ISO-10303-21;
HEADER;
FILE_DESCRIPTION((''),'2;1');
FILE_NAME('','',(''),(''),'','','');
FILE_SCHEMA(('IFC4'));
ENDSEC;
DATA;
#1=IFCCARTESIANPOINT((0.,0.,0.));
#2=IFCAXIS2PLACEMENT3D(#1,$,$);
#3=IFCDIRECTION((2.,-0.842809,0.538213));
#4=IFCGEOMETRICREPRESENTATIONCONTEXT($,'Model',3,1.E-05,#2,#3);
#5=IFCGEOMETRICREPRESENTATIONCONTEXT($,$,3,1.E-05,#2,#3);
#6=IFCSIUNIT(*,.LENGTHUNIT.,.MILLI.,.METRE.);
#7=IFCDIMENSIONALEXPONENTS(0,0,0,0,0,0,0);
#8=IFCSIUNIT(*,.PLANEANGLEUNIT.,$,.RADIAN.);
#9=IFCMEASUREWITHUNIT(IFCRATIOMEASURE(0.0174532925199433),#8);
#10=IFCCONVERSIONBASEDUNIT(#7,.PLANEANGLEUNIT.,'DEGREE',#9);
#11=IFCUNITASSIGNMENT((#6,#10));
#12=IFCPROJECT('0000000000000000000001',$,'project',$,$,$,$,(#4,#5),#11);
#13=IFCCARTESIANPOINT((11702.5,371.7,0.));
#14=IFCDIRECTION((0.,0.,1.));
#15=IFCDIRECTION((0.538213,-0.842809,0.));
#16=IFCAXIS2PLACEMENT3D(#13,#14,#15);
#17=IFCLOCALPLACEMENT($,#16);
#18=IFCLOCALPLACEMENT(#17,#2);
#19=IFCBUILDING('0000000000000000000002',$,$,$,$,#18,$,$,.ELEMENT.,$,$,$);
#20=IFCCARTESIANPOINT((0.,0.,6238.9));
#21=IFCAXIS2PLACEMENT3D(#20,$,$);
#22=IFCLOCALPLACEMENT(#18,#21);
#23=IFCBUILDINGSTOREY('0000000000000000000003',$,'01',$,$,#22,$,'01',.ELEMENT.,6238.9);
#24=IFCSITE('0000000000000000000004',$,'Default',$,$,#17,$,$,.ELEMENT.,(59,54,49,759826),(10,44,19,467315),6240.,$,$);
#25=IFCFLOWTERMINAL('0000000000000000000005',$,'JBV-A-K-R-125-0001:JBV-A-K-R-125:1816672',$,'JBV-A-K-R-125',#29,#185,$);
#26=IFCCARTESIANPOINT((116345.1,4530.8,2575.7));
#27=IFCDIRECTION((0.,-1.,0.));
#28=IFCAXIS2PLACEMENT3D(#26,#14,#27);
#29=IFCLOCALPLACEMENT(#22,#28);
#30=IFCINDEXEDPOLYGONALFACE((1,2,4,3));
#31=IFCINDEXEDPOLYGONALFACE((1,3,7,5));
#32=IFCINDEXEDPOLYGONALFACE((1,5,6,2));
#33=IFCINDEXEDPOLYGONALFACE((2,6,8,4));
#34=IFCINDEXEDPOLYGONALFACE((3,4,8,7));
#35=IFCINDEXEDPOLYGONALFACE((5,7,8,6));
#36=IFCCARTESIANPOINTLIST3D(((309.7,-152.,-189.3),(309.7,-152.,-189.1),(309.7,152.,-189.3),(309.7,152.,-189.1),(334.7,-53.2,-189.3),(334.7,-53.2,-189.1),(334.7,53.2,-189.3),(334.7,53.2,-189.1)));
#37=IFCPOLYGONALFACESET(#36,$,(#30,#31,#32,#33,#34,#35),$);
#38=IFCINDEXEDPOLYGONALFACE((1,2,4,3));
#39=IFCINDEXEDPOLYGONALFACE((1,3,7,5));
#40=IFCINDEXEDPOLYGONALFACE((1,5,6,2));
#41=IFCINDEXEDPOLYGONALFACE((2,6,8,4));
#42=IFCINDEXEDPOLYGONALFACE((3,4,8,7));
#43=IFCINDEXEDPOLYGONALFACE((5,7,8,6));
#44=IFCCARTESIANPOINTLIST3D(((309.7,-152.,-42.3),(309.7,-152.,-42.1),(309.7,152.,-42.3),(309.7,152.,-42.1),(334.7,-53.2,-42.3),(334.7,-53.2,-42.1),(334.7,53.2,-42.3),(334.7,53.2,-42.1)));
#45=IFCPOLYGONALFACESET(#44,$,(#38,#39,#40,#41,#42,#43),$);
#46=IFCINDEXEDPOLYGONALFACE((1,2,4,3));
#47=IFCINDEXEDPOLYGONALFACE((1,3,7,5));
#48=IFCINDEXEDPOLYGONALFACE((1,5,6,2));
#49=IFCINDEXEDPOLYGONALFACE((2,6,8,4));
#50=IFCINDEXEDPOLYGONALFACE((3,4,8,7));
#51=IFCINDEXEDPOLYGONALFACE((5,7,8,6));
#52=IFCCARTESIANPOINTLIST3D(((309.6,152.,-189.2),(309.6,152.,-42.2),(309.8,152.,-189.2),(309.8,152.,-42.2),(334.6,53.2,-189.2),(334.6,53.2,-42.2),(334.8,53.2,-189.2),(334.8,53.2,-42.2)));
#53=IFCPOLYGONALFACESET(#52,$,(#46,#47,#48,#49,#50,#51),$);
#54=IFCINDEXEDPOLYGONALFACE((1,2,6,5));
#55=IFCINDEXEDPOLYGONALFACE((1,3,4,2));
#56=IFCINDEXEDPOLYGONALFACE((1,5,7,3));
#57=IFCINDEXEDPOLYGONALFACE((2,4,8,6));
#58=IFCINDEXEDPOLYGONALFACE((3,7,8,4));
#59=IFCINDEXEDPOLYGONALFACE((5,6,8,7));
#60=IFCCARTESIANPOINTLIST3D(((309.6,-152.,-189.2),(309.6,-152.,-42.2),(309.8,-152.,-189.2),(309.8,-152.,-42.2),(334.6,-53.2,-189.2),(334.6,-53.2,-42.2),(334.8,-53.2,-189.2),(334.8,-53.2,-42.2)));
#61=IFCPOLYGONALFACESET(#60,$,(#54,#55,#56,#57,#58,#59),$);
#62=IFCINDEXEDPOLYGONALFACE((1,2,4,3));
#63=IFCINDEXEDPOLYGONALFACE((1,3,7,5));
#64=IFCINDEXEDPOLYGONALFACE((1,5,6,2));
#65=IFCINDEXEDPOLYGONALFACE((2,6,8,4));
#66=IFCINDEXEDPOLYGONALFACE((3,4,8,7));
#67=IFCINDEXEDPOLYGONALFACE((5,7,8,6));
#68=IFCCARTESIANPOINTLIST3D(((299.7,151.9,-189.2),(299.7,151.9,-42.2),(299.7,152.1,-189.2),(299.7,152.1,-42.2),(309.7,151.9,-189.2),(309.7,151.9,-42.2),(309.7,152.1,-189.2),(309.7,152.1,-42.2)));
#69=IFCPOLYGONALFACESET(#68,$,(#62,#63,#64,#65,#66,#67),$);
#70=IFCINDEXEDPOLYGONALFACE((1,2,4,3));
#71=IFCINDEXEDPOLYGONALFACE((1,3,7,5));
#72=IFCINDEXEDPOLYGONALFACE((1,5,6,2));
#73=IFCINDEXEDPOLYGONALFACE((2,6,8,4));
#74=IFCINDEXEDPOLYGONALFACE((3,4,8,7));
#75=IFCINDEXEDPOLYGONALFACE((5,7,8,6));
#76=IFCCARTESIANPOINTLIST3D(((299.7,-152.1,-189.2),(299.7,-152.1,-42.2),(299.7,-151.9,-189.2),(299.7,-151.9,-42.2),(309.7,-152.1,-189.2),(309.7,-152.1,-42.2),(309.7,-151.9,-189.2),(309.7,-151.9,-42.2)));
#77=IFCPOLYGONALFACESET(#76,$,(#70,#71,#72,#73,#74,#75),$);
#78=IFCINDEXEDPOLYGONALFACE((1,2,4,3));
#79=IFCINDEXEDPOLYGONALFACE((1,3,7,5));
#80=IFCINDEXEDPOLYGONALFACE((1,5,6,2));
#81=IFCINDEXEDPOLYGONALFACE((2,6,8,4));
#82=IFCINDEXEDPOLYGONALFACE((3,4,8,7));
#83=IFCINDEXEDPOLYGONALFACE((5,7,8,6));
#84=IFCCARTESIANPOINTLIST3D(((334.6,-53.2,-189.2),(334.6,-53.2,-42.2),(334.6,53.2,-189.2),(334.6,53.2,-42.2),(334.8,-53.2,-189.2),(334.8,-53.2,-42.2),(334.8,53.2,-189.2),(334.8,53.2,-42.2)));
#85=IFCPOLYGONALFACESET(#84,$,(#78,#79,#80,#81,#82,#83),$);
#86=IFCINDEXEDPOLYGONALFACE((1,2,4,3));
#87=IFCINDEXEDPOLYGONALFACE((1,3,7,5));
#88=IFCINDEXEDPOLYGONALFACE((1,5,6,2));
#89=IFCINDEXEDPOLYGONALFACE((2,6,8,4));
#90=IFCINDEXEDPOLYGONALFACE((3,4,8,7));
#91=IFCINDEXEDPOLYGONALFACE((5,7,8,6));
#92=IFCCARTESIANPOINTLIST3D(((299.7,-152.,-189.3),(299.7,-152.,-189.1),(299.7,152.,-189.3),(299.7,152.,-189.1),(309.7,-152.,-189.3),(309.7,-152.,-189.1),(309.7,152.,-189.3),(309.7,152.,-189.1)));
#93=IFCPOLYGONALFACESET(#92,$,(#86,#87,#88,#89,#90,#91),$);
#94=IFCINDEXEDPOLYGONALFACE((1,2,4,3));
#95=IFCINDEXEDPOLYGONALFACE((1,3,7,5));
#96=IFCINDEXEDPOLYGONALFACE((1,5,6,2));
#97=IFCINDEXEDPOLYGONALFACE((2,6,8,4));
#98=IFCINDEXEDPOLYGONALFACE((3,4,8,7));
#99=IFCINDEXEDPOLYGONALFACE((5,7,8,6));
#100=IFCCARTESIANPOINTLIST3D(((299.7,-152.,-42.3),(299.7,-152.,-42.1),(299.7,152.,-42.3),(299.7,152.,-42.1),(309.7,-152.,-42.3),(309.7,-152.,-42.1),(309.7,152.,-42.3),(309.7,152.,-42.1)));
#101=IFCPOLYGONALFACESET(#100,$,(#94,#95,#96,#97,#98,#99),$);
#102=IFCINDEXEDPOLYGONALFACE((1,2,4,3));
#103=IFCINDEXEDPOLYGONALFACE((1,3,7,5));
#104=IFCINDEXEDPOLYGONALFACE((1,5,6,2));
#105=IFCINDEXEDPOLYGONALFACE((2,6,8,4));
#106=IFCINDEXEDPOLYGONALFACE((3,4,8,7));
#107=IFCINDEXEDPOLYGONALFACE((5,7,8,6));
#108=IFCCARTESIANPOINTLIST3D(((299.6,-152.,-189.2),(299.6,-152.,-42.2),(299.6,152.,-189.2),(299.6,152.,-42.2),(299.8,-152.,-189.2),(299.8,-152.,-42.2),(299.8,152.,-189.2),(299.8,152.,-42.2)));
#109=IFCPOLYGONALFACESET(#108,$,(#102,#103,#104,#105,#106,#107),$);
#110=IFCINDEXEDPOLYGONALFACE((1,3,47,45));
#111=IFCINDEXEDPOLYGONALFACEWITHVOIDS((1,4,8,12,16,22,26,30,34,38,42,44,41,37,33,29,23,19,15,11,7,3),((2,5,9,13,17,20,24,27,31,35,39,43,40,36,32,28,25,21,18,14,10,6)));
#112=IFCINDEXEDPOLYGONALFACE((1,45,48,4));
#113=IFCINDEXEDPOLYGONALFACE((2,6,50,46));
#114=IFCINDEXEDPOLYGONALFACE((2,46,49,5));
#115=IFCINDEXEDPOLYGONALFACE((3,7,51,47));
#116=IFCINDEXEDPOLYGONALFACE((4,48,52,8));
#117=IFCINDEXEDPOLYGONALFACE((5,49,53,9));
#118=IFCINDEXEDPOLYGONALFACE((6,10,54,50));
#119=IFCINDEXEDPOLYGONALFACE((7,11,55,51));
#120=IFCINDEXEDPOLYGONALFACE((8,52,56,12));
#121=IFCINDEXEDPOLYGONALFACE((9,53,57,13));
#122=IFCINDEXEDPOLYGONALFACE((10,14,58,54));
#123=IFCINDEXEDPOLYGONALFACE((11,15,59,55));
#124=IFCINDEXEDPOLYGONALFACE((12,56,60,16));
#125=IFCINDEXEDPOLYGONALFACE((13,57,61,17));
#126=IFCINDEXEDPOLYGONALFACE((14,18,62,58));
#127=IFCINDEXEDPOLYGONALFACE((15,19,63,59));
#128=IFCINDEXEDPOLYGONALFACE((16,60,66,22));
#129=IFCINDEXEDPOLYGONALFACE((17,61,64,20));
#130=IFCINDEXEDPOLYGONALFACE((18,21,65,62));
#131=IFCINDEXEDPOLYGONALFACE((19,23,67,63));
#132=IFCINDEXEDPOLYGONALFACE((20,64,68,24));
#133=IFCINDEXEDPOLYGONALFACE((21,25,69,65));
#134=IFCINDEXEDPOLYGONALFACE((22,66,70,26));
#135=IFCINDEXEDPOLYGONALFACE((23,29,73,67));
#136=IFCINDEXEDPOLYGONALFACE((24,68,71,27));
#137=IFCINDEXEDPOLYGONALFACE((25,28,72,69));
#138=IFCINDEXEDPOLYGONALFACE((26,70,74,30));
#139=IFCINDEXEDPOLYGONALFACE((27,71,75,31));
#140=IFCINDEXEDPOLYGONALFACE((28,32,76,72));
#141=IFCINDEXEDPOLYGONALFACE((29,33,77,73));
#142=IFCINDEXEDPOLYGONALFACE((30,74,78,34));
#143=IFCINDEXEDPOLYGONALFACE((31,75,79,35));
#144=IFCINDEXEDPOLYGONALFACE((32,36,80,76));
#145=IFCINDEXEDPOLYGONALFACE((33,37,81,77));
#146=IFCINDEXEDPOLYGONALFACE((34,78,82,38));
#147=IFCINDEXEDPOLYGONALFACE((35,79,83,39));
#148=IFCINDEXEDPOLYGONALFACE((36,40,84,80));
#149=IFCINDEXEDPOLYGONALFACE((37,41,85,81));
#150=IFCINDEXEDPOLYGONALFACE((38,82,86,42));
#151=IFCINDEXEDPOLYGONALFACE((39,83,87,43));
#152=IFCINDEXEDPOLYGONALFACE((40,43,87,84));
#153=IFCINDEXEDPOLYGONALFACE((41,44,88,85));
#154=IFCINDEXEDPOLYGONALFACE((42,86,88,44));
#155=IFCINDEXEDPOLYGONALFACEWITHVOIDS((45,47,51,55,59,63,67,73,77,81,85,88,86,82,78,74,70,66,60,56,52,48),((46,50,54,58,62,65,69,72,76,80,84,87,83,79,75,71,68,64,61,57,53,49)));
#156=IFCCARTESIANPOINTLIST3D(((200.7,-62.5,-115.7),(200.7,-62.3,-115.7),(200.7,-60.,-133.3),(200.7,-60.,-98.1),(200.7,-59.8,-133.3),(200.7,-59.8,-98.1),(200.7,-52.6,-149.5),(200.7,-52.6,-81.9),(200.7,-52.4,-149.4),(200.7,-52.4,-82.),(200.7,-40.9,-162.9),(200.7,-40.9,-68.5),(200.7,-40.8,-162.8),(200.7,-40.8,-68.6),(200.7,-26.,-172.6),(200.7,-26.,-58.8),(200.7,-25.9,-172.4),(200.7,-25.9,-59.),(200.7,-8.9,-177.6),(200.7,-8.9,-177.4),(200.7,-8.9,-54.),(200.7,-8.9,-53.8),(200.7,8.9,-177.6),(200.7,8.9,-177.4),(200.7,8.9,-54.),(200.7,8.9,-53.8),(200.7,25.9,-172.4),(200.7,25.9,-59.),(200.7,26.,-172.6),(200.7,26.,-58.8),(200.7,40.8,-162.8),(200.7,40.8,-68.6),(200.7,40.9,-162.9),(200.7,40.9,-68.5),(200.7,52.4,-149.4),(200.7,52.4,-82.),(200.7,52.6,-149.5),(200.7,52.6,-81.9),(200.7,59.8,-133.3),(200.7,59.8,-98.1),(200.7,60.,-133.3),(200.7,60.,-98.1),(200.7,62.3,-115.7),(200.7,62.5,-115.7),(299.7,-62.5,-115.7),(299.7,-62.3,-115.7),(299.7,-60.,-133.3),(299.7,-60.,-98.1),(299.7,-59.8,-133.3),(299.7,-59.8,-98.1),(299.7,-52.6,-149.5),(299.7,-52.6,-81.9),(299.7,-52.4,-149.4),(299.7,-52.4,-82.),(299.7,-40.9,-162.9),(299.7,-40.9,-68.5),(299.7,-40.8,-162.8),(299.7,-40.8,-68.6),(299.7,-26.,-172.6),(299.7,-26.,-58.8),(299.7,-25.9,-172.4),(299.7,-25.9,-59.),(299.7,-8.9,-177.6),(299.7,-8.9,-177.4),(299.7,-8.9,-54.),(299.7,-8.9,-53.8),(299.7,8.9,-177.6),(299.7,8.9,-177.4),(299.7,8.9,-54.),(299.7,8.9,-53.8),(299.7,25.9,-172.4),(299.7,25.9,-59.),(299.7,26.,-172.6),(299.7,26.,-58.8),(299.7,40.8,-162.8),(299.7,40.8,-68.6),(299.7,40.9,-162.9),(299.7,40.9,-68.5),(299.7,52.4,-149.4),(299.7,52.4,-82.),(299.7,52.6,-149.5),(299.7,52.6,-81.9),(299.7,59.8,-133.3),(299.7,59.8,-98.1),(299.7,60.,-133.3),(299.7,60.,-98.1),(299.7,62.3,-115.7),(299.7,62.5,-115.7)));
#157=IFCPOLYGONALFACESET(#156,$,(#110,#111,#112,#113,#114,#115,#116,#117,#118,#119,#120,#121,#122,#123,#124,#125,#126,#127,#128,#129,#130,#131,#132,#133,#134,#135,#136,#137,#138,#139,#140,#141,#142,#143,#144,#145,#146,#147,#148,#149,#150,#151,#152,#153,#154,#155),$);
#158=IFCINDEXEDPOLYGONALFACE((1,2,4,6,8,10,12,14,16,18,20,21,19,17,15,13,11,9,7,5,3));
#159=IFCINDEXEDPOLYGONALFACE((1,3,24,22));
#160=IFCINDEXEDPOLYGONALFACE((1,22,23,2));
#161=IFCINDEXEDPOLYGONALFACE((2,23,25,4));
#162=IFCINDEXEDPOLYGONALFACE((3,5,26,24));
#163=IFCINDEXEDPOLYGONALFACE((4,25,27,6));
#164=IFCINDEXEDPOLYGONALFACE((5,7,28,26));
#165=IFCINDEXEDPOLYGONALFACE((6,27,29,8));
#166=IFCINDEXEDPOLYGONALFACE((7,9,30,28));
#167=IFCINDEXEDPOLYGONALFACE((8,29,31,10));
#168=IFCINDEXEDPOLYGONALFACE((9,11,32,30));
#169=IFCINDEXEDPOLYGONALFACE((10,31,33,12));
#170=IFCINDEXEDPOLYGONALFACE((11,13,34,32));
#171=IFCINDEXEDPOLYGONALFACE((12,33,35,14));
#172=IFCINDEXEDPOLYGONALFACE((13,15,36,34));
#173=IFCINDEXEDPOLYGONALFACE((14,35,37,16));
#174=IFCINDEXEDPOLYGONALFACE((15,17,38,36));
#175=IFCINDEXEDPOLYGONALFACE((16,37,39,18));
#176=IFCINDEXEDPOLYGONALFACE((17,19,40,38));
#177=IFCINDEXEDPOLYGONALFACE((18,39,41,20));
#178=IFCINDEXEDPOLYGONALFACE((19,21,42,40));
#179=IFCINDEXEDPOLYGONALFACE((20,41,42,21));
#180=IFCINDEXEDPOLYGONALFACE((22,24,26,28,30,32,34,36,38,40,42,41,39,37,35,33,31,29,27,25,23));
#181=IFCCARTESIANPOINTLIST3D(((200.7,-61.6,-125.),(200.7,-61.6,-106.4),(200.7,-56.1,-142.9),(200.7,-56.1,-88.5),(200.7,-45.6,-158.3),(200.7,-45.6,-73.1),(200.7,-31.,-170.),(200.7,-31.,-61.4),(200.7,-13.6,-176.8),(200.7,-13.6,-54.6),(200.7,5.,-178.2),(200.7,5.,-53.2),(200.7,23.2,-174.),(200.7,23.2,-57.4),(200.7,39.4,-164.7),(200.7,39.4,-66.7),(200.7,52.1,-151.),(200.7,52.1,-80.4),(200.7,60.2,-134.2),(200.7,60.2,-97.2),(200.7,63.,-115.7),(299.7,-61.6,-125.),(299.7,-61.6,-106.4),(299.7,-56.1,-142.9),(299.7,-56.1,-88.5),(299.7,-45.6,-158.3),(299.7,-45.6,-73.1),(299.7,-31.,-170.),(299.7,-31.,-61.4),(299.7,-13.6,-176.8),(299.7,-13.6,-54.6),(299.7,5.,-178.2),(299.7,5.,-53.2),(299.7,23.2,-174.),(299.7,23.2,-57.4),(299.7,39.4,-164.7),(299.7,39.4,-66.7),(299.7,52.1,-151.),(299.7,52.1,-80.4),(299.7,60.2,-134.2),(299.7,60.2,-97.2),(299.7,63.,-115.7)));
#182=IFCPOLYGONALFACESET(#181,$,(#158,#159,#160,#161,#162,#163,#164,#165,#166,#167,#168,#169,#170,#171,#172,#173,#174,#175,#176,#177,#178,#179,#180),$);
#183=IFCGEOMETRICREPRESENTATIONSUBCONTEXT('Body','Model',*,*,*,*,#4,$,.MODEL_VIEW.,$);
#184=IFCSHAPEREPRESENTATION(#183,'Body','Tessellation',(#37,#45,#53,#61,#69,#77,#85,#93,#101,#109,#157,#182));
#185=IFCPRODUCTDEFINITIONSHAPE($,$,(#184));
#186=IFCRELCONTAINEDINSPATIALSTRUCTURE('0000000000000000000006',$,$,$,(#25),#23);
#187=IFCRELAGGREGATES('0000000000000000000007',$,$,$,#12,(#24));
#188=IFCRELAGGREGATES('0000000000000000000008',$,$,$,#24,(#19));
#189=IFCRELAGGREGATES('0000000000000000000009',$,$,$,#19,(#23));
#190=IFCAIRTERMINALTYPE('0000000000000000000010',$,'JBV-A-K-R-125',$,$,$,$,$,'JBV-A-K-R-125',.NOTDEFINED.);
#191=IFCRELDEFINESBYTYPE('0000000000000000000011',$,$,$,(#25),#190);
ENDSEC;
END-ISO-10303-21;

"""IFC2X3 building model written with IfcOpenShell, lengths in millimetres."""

from ifc_helpers import new_model, entity, si_unit, converted_unit, direction, frame, frame_2d, origin, origin_2d_with_axis, place, context, subcontext, project, spatial, polyline, circle_curve, parameter, trimmed, segment, composite_curve, rectangle, circle, outline, extrude, source, transform, mapped, type_object, type_shapes, element, save


model = new_model("IFC2X3")

# Units and contexts
model_context = context("Model", 3, precision=1e-05, world=origin(), true_north=direction((2.0, -0.842809, 0.538213)))
context_of_model = context(None, 3, precision=1e-05, world=origin(), true_north=direction((2.0, -0.842809, 0.538213)))
body_context = subcontext(model_context, "Body", "Model", "MODEL_VIEW")
ifc_project = project(units=[si_unit("LENGTHUNIT", "METRE", prefix="MILLI"), converted_unit("PLANEANGLEUNIT", "DEGREE", entity("IfcRatioMeasure", 0.0174532925199433), si_unit("PLANEANGLEUNIT", "RADIAN"), dimensions=[0, 0, 0, 0, 0, 0, 0])], contexts=[model_context, context_of_model])

# Site, building, storey
site_placement = place(None, frame((11702.5, 371.7, 0.0), z_axis=(0.0, 0.0, 1.0), x_axis=(0.538213, -0.842809, 0.0)))
site = spatial("IfcSite", under=ifc_project, at=site_placement, Name="Default", CompositionType="ELEMENT", RefLatitude=(59, 54, 49, 759826), RefLongitude=(10, 44, 19, 467315), RefElevation=6240.0)
building_placement = place(site_placement, origin())
building = spatial("IfcBuilding", under=site, at=building_placement, CompositionType="ELEMENT")
storey_placement = place(building_placement, frame((0.0, 0.0, 6238.9)))
storey = spatial("IfcBuildingStorey", under=building, at=storey_placement, Name="01", LongName="01", CompositionType="ELEMENT", Elevation=6238.9)

# Flow terminal
air_terminal_type_1 = type_object("IfcAirTerminalType", Name="JBV-A-K-R-125", ElementType="JBV-A-K-R-125", PredefinedType="NOTDEFINED")
shared_shape_1 = source(origin(), body_context, "Body", "SweptSolid", [
    extrude(outline(polyline([(-152.0, -12.5), (152.0, -12.5), (53.2, 12.5), (-53.2, 12.5), (-152.0, -12.5)])), frame((322.2, 0.0, -189.3), z_axis=(0.0, 0.0, 1.0), x_axis=(0.0, -1.0, 0.0)), (0.0, 0.0, 1.0), 0.2),
    extrude(outline(polyline([(-152.0, -12.5), (152.0, -12.5), (53.2, 12.5), (-53.2, 12.5), (-152.0, -12.5)])), frame((322.2, 0.0, -42.3), z_axis=(0.0, 0.0, 1.0), x_axis=(0.0, -1.0, 0.0)), (0.0, 0.0, 1.0), 0.2),
    extrude(rectangle(XDim=0.2, YDim=101.9, at=frame_2d((0.0, 0.0), x_axis=(1.0, 0.0))), frame((322.2, 102.6, -189.2), z_axis=(0.0, 0.0, 1.0), x_axis=(0.969446, 0.245305, 0.0)), (0.0, 0.0, 1.0), 147.0),
    extrude(rectangle(XDim=0.2, YDim=101.9, at=frame_2d((0.0, 0.0), x_axis=(1.0, 0.0))), frame((322.2, -102.6, -189.2), z_axis=(0.0, 0.0, 1.0), x_axis=(-0.969446, 0.245305, 0.0)), (0.0, 0.0, 1.0), 147.0),
    extrude(rectangle(XDim=0.2, YDim=10.0, at=frame_2d((0.0, 0.0), x_axis=(1.0, 0.0))), frame((304.7, 152.0, -189.2), z_axis=(0.0, 0.0, 1.0), x_axis=(0.0, 1.0, 0.0)), (0.0, 0.0, 1.0), 147.0),
    extrude(rectangle(XDim=0.2, YDim=10.0, at=frame_2d((0.0, 0.0), x_axis=(1.0, 0.0))), frame((304.7, -152.0, -189.2), z_axis=(0.0, 0.0, 1.0), x_axis=(0.0, 1.0, 0.0)), (0.0, 0.0, 1.0), 147.0),
    extrude(rectangle(XDim=0.2, YDim=106.4, at=frame_2d((0.0, 0.0), x_axis=(1.0, 0.0))), frame((334.7, 0.0, -189.2)), (0.0, 0.0, 1.0), 147.0),
    extrude(rectangle(XDim=304.0, YDim=10.0, at=frame_2d((0.0, 0.0), x_axis=(1.0, 0.0))), frame((304.7, 0.0, -189.3), z_axis=(0.0, 0.0, 1.0), x_axis=(0.0, -1.0, 0.0)), (0.0, 0.0, 1.0), 0.2),
    extrude(rectangle(XDim=304.0, YDim=10.0, at=frame_2d((0.0, 0.0), x_axis=(1.0, 0.0))), frame((304.7, 0.0, -42.3), z_axis=(0.0, 0.0, 1.0), x_axis=(0.0, -1.0, 0.0)), (0.0, 0.0, 1.0), 0.2),
    extrude(rectangle(XDim=0.2, YDim=304.0, at=frame_2d((0.0, 0.0), x_axis=(1.0, 0.0))), frame((299.7, 0.0, -189.2)), (0.0, 0.0, 1.0), 147.0),
    extrude(outline(composite_curve([segment(trimmed(circle_curve(origin_2d_with_axis(), 62.5), [parameter(0.0)], [parameter(180.0)], True, "PARAMETER"), True, "CONTINUOUS"), segment(trimmed(circle_curve(origin_2d_with_axis(), 62.5), [parameter(180.0)], [parameter(360.0)], True, "PARAMETER"), True, "CONTINUOUS")], self_intersect=False), holes=[composite_curve([segment(trimmed(circle_curve(origin_2d_with_axis(), 62.3), [parameter(180.0)], [parameter(360.0)], True, "PARAMETER"), False, "CONTINUOUS"), segment(trimmed(circle_curve(origin_2d_with_axis(), 62.3), [parameter(0.0)], [parameter(180.0)], True, "PARAMETER"), False, "CONTINUOUS")], self_intersect=False)]), frame((200.7, 0.0, -115.7), z_axis=(1.0, 0.0, 0.0), x_axis=(0.0, 1.0, 0.0)), (0.0, 0.0, 1.0), 99.0),
    extrude(circle(Radius=62.6, at=frame_2d((0.0, 0.0), x_axis=(1.0, 0.0))), frame((200.7, 0.3, -115.7), z_axis=(1.0, 0.0, 0.0), x_axis=(0.0, 1.0, 0.0)), (0.0, 0.0, 1.0), 99.0),
])
type_shapes(air_terminal_type_1, [shared_shape_1])
for number, where, z_axis, x_axis, name in (
    (1, (116345.1, 4530.8, 2575.7), (0.0, 0.0, 1.0), (0.0, -1.0, 0.0), "JBV-A-K-R-125-0001:JBV-A-K-R-125:1816672"),
):
    element("IfcFlowTerminal", number, at=place(storey_placement, frame(where, z_axis=z_axis, x_axis=x_axis)), inside=storey, type_object=air_terminal_type_1, Name=name, ObjectType="JBV-A-K-R-125", context=body_context, shape_type="MappedRepresentation", body=[
        mapped(shared_shape_1, transform((0.0, 0.0, 0.0), scale=1.0)),
    ])

save(model, "model.ifc")
